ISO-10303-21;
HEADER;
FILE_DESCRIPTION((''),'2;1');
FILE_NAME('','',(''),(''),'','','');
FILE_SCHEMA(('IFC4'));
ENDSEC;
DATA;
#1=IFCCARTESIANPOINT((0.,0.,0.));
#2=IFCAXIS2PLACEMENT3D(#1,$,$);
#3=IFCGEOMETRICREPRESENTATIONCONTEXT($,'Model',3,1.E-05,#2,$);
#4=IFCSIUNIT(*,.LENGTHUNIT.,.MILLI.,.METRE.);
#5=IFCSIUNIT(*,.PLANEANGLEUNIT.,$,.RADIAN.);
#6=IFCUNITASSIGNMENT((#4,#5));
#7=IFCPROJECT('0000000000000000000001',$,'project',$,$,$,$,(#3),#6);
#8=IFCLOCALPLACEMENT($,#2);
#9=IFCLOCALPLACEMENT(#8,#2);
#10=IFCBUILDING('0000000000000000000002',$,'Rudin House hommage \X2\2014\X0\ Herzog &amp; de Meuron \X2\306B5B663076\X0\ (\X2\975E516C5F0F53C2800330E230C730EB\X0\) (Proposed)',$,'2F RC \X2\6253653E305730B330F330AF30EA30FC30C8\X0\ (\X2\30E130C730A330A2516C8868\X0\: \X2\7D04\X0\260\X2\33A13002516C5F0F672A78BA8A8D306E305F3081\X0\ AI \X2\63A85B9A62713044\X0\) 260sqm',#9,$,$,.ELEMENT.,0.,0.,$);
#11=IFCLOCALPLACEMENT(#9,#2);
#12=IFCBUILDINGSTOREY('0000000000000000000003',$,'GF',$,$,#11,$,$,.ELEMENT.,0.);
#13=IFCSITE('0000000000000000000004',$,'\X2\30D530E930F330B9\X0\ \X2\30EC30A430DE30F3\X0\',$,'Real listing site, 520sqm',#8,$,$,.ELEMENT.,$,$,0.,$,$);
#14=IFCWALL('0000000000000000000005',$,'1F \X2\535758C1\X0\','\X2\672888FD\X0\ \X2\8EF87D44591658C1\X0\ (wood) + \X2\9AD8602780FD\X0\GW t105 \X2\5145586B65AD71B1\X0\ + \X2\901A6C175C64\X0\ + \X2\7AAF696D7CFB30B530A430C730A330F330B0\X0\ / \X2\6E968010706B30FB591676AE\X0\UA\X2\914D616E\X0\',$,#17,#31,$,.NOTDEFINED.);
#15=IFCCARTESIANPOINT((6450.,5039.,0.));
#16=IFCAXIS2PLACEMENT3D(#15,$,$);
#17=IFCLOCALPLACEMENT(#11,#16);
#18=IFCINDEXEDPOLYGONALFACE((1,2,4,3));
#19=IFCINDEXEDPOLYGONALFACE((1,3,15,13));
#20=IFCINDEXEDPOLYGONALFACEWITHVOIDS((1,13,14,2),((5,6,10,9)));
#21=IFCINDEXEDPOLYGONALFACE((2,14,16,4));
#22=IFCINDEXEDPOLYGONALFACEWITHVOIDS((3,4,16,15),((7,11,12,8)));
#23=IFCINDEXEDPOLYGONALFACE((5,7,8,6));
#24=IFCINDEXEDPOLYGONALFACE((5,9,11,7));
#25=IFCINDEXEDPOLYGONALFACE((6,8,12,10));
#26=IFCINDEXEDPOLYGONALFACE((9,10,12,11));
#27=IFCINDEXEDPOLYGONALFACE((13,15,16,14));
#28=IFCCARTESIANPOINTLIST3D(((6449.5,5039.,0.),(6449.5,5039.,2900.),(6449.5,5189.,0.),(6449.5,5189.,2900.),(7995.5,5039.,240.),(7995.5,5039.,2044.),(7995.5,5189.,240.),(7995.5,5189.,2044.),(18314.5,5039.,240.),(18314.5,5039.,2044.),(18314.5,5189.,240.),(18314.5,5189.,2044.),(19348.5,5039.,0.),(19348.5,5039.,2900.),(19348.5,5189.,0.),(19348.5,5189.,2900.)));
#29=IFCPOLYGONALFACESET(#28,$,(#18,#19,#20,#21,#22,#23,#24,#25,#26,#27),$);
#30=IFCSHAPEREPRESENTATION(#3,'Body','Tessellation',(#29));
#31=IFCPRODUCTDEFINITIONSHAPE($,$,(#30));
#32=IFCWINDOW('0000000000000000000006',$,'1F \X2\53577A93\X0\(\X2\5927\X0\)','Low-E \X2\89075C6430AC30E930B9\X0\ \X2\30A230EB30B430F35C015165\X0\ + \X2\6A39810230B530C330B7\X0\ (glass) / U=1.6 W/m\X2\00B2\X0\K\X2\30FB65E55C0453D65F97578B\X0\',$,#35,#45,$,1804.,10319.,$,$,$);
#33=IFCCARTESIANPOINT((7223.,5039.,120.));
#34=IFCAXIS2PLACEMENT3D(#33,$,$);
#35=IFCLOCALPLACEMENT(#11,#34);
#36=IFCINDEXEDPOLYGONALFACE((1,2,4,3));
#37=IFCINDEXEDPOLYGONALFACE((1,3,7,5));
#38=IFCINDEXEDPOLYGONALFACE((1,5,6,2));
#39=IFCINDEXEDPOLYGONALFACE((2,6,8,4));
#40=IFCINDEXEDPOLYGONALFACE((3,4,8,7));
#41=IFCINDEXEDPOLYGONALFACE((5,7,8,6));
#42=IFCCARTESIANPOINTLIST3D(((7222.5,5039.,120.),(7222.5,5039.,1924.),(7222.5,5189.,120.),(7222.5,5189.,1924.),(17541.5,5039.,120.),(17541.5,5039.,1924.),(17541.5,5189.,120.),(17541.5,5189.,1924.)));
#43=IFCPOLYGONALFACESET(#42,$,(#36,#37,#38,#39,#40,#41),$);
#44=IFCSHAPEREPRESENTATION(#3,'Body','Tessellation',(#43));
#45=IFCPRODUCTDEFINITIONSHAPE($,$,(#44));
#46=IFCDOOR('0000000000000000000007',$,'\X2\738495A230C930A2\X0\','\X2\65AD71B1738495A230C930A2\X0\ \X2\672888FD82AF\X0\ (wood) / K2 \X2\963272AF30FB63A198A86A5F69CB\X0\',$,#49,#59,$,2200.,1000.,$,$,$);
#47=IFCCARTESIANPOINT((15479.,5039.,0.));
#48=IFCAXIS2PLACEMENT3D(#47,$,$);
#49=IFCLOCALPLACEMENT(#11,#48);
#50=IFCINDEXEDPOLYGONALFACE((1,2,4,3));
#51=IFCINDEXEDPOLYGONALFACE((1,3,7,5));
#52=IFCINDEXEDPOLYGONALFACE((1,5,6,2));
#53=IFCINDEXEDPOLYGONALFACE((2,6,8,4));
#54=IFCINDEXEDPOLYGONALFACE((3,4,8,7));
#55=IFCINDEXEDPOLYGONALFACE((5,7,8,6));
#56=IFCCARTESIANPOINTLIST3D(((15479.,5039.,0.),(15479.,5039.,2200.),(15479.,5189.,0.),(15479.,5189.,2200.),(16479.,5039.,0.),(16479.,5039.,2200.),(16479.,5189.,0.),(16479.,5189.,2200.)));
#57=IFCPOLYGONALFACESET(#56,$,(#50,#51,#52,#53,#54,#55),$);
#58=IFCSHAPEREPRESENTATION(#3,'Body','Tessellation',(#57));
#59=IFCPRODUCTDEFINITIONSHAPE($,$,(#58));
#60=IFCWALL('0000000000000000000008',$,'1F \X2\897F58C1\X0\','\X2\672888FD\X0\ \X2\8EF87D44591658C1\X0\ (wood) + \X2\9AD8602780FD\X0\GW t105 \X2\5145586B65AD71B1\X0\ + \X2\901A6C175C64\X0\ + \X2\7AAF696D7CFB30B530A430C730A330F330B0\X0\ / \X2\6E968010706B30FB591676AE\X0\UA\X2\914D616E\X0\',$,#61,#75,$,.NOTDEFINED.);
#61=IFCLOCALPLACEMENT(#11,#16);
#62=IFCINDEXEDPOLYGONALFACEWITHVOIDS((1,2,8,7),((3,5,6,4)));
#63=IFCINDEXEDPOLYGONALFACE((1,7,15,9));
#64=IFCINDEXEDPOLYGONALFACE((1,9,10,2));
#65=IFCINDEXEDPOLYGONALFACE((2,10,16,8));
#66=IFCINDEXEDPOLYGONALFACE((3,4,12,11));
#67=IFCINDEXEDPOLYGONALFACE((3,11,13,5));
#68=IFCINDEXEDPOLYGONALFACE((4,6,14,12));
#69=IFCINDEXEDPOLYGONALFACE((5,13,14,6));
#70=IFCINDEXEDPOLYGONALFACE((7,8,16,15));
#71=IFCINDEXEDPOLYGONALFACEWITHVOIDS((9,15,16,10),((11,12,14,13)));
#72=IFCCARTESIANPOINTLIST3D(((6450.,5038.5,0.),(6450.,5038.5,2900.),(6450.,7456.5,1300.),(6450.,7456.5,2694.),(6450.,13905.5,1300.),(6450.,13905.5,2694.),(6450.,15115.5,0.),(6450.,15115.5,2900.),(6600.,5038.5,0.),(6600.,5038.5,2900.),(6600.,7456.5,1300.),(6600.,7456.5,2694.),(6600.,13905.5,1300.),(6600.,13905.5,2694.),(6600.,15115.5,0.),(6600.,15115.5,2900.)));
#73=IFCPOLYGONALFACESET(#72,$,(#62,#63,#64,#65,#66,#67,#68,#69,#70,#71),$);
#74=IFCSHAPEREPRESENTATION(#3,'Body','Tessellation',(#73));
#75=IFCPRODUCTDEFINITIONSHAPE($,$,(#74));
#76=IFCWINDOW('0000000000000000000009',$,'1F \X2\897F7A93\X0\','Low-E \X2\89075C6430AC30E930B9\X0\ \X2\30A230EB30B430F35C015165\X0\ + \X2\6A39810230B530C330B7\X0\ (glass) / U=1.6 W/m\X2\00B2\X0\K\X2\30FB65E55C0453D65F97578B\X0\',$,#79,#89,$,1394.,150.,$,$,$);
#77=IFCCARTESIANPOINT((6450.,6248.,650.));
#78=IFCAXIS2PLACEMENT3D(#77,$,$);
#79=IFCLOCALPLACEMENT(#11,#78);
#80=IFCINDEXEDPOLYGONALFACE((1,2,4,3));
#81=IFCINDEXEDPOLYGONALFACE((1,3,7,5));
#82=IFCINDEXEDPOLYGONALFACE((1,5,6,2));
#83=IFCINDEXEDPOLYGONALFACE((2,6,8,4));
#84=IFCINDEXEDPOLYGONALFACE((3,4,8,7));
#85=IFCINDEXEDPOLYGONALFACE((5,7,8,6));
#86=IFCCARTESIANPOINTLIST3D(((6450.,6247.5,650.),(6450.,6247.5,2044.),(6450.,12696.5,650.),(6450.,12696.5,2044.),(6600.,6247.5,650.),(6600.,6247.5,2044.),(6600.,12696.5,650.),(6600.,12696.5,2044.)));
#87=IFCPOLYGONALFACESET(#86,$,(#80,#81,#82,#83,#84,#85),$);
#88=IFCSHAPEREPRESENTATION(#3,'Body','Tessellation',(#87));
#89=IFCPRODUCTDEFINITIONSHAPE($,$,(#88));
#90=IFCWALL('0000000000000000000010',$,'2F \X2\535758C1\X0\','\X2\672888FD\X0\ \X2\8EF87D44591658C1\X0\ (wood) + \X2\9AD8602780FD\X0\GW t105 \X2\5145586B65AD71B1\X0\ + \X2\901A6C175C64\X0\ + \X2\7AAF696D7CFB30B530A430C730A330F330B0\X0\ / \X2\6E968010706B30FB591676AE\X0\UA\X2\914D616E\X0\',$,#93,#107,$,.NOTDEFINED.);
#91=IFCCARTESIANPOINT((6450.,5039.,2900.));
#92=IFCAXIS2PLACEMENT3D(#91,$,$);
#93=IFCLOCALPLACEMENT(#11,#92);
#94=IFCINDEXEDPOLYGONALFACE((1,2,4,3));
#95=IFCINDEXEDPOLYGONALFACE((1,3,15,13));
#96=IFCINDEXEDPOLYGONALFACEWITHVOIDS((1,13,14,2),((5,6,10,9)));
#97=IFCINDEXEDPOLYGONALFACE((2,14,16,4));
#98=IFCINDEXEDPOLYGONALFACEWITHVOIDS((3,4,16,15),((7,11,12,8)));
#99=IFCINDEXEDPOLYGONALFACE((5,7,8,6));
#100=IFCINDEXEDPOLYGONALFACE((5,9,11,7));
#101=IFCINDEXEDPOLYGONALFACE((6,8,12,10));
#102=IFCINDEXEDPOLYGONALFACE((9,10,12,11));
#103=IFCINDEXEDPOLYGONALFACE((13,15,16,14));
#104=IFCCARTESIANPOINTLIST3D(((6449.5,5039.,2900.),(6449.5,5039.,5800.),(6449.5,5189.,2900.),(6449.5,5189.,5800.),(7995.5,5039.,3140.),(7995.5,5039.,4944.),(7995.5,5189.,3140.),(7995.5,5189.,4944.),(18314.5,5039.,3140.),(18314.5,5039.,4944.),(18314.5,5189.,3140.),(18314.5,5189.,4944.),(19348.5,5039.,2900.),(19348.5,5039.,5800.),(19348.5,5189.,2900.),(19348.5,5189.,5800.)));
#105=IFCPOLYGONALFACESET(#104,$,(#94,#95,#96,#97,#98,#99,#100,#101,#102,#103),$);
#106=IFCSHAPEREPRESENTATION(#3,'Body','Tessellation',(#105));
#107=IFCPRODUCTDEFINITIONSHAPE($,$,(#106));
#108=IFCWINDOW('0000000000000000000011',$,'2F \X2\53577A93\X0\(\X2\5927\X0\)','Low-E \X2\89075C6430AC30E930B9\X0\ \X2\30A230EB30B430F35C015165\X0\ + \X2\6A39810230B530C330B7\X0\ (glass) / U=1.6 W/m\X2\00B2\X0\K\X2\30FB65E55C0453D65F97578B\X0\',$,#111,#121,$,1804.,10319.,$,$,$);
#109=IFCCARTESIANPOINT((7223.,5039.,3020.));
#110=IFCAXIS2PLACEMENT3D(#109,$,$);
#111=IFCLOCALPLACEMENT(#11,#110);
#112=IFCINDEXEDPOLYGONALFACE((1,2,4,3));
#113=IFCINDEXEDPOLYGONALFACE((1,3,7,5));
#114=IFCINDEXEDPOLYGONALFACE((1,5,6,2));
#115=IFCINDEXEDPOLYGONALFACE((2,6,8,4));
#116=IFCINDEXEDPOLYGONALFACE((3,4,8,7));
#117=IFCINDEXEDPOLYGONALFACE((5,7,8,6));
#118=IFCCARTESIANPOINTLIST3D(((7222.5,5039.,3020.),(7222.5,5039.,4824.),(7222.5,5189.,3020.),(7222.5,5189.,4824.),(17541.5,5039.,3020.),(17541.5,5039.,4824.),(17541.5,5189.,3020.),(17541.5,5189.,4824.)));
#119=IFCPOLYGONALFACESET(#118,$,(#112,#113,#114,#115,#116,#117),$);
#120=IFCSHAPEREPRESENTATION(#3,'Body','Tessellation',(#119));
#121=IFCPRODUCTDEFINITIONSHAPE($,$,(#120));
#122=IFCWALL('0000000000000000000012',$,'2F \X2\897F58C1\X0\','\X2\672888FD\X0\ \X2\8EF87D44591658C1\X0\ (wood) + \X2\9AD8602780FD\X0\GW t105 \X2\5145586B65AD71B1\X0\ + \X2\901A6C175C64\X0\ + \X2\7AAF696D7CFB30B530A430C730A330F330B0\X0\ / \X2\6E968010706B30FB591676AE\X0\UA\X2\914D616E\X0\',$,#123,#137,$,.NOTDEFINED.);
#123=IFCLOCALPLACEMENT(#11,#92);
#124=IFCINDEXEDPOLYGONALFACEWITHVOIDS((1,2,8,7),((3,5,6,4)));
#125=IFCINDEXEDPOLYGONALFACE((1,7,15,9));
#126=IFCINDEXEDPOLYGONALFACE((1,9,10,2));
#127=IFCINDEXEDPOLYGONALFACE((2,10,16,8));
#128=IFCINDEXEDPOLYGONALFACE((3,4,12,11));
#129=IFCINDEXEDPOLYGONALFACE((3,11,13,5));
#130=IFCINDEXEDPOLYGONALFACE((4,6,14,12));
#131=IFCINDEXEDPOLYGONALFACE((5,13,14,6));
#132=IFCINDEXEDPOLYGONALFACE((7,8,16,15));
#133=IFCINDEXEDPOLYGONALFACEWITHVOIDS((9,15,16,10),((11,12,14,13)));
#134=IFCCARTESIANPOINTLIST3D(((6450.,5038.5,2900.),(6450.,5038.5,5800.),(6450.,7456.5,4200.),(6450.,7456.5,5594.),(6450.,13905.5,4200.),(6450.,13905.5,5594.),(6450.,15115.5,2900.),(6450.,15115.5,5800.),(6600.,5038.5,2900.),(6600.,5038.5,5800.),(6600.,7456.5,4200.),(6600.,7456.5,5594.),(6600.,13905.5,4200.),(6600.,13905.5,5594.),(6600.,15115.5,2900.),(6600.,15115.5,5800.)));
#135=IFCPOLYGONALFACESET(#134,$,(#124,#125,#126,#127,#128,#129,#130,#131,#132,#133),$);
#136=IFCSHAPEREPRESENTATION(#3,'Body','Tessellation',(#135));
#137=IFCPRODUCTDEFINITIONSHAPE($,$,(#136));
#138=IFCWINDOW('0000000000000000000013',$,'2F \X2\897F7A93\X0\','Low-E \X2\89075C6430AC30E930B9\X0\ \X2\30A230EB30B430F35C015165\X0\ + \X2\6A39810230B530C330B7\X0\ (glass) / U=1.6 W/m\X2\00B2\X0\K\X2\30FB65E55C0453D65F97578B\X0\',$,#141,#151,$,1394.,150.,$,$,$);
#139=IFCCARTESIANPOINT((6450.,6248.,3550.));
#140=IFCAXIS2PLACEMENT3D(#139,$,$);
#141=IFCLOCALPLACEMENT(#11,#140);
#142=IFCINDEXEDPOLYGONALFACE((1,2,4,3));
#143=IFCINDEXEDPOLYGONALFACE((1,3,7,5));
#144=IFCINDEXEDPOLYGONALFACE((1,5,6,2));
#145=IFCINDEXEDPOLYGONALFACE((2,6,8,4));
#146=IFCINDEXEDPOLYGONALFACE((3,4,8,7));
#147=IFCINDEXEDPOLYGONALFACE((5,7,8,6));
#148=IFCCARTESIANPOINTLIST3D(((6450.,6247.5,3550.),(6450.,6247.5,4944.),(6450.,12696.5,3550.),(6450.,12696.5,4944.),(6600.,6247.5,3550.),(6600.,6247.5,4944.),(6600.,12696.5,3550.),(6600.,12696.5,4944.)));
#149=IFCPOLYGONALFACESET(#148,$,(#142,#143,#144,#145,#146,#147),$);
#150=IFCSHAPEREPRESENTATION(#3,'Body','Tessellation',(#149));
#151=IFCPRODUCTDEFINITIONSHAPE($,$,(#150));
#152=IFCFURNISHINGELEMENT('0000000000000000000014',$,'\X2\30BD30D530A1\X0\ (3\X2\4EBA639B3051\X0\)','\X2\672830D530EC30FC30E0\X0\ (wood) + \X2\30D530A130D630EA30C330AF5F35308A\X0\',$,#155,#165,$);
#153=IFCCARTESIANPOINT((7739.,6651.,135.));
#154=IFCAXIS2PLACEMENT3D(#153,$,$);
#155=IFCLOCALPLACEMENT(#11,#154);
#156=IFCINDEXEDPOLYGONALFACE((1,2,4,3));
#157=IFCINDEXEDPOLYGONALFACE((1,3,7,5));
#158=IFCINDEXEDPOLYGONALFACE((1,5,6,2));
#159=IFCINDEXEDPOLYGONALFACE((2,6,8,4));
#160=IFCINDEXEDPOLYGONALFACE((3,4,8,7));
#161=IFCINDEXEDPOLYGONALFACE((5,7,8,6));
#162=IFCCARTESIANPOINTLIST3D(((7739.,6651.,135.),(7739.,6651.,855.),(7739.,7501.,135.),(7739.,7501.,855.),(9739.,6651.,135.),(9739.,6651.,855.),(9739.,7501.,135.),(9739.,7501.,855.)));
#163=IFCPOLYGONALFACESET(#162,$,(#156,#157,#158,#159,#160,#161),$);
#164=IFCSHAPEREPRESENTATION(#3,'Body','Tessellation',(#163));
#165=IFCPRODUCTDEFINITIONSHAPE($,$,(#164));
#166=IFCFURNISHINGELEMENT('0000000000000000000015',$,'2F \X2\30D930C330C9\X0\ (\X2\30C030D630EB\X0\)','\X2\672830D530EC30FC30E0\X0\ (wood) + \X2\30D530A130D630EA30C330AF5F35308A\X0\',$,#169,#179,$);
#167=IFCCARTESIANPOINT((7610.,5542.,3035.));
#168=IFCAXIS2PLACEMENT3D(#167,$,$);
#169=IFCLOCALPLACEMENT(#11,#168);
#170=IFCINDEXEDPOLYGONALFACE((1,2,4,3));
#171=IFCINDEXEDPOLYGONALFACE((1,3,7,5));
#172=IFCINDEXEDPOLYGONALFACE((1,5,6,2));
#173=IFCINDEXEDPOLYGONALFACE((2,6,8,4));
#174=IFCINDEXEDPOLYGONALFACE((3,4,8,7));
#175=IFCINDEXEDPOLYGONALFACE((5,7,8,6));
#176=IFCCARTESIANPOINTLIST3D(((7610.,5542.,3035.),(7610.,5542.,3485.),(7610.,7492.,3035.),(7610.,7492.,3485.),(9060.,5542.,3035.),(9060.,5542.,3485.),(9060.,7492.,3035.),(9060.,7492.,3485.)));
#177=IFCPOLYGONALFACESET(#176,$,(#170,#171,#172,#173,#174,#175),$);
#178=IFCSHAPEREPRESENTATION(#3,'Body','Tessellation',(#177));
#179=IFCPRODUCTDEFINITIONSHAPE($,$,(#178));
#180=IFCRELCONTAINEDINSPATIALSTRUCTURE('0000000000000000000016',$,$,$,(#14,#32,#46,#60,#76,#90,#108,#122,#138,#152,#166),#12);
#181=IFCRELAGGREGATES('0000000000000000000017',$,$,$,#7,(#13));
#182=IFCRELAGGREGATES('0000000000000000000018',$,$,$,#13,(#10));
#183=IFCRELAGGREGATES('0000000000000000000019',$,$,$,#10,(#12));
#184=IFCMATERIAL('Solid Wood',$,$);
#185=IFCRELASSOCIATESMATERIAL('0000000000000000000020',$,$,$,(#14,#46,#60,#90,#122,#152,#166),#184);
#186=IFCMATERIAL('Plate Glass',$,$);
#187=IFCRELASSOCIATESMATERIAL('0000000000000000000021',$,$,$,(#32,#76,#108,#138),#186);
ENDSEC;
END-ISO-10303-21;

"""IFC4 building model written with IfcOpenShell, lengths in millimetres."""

from ifc_helpers import new_model, si_unit, frame, frame_2d, origin, place, context, project, spatial, rectangle, extrude, material, element, fill, save


model = new_model("IFC4")

# Units and contexts
model_context = context("Model", 3, precision=1e-05, world=origin())
ifc_project = project(units=[si_unit("LENGTHUNIT", "METRE", prefix="MILLI"), si_unit("PLANEANGLEUNIT", "RADIAN")], contexts=[model_context])

# Site, building, storey
site_placement = place(None, origin())
site = spatial("IfcSite", under=ifc_project, at=site_placement, Name="フランス レイマン", ObjectType="Real listing site, 520sqm", CompositionType="ELEMENT", RefElevation=0.0)
building_placement = place(site_placement, origin())
building = spatial("IfcBuilding", under=site, at=building_placement, Name="Rudin House hommage — Herzog &amp; de Meuron に学ぶ (非公式参考モデル) (Proposed)", ObjectType="2F RC 打放しコンクリート (メディア公表: 約260㎡。公式未確認のため AI 推定扱い) 260sqm", CompositionType="ELEMENT", ElevationOfRefHeight=0.0, ElevationOfTerrain=0.0)
storey_placement = place(building_placement, origin())
storey = spatial("IfcBuildingStorey", under=building, at=storey_placement, Name="GF", CompositionType="ELEMENT", Elevation=0.0)

# Shared definitions
ifc_material_1 = material(Name="Solid Wood")

# Wall, openings, window, door
wall_1_placement = place(storey_placement, frame((6450.0, 5039.0, 0.0)))
wall_1 = element("IfcWall", 1, at=wall_1_placement, inside=storey, material=ifc_material_1, Name="1F 南壁", Description="木製 軸組外壁 (wood) + 高性能GW t105 充填断熱 + 通気層 + 窯業系サイディング / 準耐火・外皮UA配慮", PredefinedType="NOTDEFINED", context=model_context, shape_type="SweptSolid", body=[
    extrude(rectangle(XDim=12899.0, YDim=150.0, at=frame_2d((6449.0, 75.0))), frame((6450.0, 5039.0, 0.0)), (0.0, 0.0, 1.0), 2900.0),
])
opening_1_placement = place(storey_placement, frame((7223.0, 5039.0, 120.0)))
opening_1 = element("IfcOpeningElement", 2, at=opening_1_placement, cuts=wall_1, PredefinedType="NOTDEFINED", context=model_context, shape_type="SweptSolid", body=[
    extrude(rectangle(XDim=10319.0, YDim=150.0, at=frame_2d((5159.0, 75.0))), frame((7223.0, 5039.0, 120.0)), (0.0, 0.0, 1.0), 1804.0),
])
opening_2_placement = place(storey_placement, frame((15479.0, 5039.0, 0.0)))
opening_2 = element("IfcOpeningElement", 3, at=opening_2_placement, cuts=wall_1, PredefinedType="NOTDEFINED", context=model_context, shape_type="SweptSolid", body=[
    extrude(rectangle(XDim=1000.0, YDim=150.0, at=frame_2d((500.0, 75.0))), frame((15479.0, 5039.0, 0.0)), (0.0, 0.0, 1.0), 2200.0),
])
ifc_material_2 = material(Name="Plate Glass")
window_1_placement = place(storey_placement, frame((7223.0, 5039.0, 120.0)))
window_1 = element("IfcWindow", 4, at=window_1_placement, inside=storey, material=ifc_material_2, Name="1F 南窓(大)", Description="Low-E 複層ガラス アルゴン封入 + 樹脂サッシ (glass) / U=1.6 W/m²K・日射取得型", OverallHeight=1804.0, OverallWidth=10319.0, context=model_context, shape_type="SweptSolid", body=[
    extrude(rectangle(XDim=10319.0, YDim=150.0, at=frame_2d((5159.0, 75.0))), frame((7223.0, 5039.0, 120.0)), (0.0, 0.0, 1.0), 1804.0),
])
fill(opening_1, window_1)
door_placement = place(storey_placement, frame((15479.0, 5039.0, 0.0)))
door = element("IfcDoor", 5, at=door_placement, inside=storey, material=ifc_material_1, Name="玄関ドア", Description="断熱玄関ドア 木製芯 (wood) / K2 防犯・採風機構", OverallHeight=2200.0, OverallWidth=1000.0, context=model_context, shape_type="SweptSolid", body=[
    extrude(rectangle(XDim=1000.0, YDim=150.0, at=frame_2d((500.0, 75.0))), frame((15479.0, 5039.0, 0.0)), (0.0, 0.0, 1.0), 2200.0),
])
fill(opening_2, door)

# Wall, opening, window
wall_2_placement = place(storey_placement, frame((6450.0, 5039.0, 0.0)))
wall_2 = element("IfcWall", 6, at=wall_2_placement, inside=storey, material=ifc_material_1, Name="1F 西壁", Description="木製 軸組外壁 (wood) + 高性能GW t105 充填断熱 + 通気層 + 窯業系サイディング / 準耐火・外皮UA配慮", PredefinedType="NOTDEFINED", context=model_context, shape_type="SweptSolid", body=[
    extrude(rectangle(XDim=150.0, YDim=10077.0, at=frame_2d((75.0, 5038.0))), frame((6450.0, 5039.0, 0.0)), (0.0, 0.0, 1.0), 2900.0),
])
opening_3_placement = place(storey_placement, frame((6450.0, 6248.0, 650.0)))
opening_3 = element("IfcOpeningElement", 7, at=opening_3_placement, cuts=wall_2, PredefinedType="NOTDEFINED", context=model_context, shape_type="SweptSolid", body=[
    extrude(rectangle(XDim=150.0, YDim=6449.0, at=frame_2d((75.0, 3224.0))), frame((6450.0, 6248.0, 650.0)), (0.0, 0.0, 1.0), 1394.0),
])
window_2_placement = place(storey_placement, frame((6450.0, 6248.0, 650.0)))
window_2 = element("IfcWindow", 8, at=window_2_placement, inside=storey, material=ifc_material_2, Name="1F 西窓", Description="Low-E 複層ガラス アルゴン封入 + 樹脂サッシ (glass) / U=1.6 W/m²K・日射取得型", OverallHeight=1394.0, OverallWidth=150.0, context=model_context, shape_type="SweptSolid", body=[
    extrude(rectangle(XDim=150.0, YDim=6449.0, at=frame_2d((75.0, 3224.0))), frame((6450.0, 6248.0, 650.0)), (0.0, 0.0, 1.0), 1394.0),
])
fill(opening_3, window_2)

# Walls, openings, windows
wall_3_placement = place(storey_placement, frame((6450.0, 5039.0, 2900.0)))
wall_3 = element("IfcWall", 9, at=wall_3_placement, inside=storey, material=ifc_material_1, Name="2F 南壁", Description="木製 軸組外壁 (wood) + 高性能GW t105 充填断熱 + 通気層 + 窯業系サイディング / 準耐火・外皮UA配慮", PredefinedType="NOTDEFINED", context=model_context, shape_type="SweptSolid", body=[
    extrude(rectangle(XDim=12899.0, YDim=150.0, at=frame_2d((6449.0, 75.0))), frame((6450.0, 5039.0, 2900.0)), (0.0, 0.0, 1.0), 2900.0),
])
opening_4_placement = place(storey_placement, frame((7223.0, 5039.0, 3020.0)))
opening_4 = element("IfcOpeningElement", 10, at=opening_4_placement, cuts=wall_3, PredefinedType="NOTDEFINED", context=model_context, shape_type="SweptSolid", body=[
    extrude(rectangle(XDim=10319.0, YDim=150.0, at=frame_2d((5159.0, 75.0))), frame((7223.0, 5039.0, 3020.0)), (0.0, 0.0, 1.0), 1804.0),
])
window_3_placement = place(storey_placement, frame((7223.0, 5039.0, 3020.0)))
window_3 = element("IfcWindow", 11, at=window_3_placement, inside=storey, material=ifc_material_2, Name="2F 南窓(大)", Description="Low-E 複層ガラス アルゴン封入 + 樹脂サッシ (glass) / U=1.6 W/m²K・日射取得型", OverallHeight=1804.0, OverallWidth=10319.0, context=model_context, shape_type="SweptSolid", body=[
    extrude(rectangle(XDim=10319.0, YDim=150.0, at=frame_2d((5159.0, 75.0))), frame((7223.0, 5039.0, 3020.0)), (0.0, 0.0, 1.0), 1804.0),
])
fill(opening_4, window_3)
wall_4_placement = place(storey_placement, frame((6450.0, 5039.0, 2900.0)))
wall_4 = element("IfcWall", 12, at=wall_4_placement, inside=storey, material=ifc_material_1, Name="2F 西壁", Description="木製 軸組外壁 (wood) + 高性能GW t105 充填断熱 + 通気層 + 窯業系サイディング / 準耐火・外皮UA配慮", PredefinedType="NOTDEFINED", context=model_context, shape_type="SweptSolid", body=[
    extrude(rectangle(XDim=150.0, YDim=10077.0, at=frame_2d((75.0, 5038.0))), frame((6450.0, 5039.0, 2900.0)), (0.0, 0.0, 1.0), 2900.0),
])
opening_5_placement = place(storey_placement, frame((6450.0, 6248.0, 3550.0)))
opening_5 = element("IfcOpeningElement", 13, at=opening_5_placement, cuts=wall_4, PredefinedType="NOTDEFINED", context=model_context, shape_type="SweptSolid", body=[
    extrude(rectangle(XDim=150.0, YDim=6449.0, at=frame_2d((75.0, 3224.0))), frame((6450.0, 6248.0, 3550.0)), (0.0, 0.0, 1.0), 1394.0),
])
window_4_placement = place(storey_placement, frame((6450.0, 6248.0, 3550.0)))
window_4 = element("IfcWindow", 14, at=window_4_placement, inside=storey, material=ifc_material_2, Name="2F 西窓", Description="Low-E 複層ガラス アルゴン封入 + 樹脂サッシ (glass) / U=1.6 W/m²K・日射取得型", OverallHeight=1394.0, OverallWidth=150.0, context=model_context, shape_type="SweptSolid", body=[
    extrude(rectangle(XDim=150.0, YDim=6449.0, at=frame_2d((75.0, 3224.0))), frame((6450.0, 6248.0, 3550.0)), (0.0, 0.0, 1.0), 1394.0),
])
fill(opening_5, window_4)

# Furnishing elements
furnishing_1_placement = place(storey_placement, frame((7739.0, 6651.0, 135.0)))
element("IfcFurnishingElement", 15, at=furnishing_1_placement, inside=storey, material=ifc_material_1, Name="ソファ (3人掛け)", Description="木フレーム (wood) + ファブリック張り", context=model_context, shape_type="SweptSolid", body=[
    extrude(rectangle(XDim=2000.0, YDim=850.0, at=frame_2d((1000.0, 425.0))), frame((7739.0, 6651.0, 135.0)), (0.0, 0.0, 1.0), 720.0),
])
furnishing_2_placement = place(storey_placement, frame((7610.0, 5542.0, 3035.0)))
element("IfcFurnishingElement", 16, at=furnishing_2_placement, inside=storey, material=ifc_material_1, Name="2F ベッド (ダブル)", Description="木フレーム (wood) + ファブリック張り", context=model_context, shape_type="SweptSolid", body=[
    extrude(rectangle(XDim=1450.0, YDim=1950.0, at=frame_2d((725.0, 975.0))), frame((7610.0, 5542.0, 3035.0)), (0.0, 0.0, 1.0), 450.0),
])

save(model, "model.ifc")
